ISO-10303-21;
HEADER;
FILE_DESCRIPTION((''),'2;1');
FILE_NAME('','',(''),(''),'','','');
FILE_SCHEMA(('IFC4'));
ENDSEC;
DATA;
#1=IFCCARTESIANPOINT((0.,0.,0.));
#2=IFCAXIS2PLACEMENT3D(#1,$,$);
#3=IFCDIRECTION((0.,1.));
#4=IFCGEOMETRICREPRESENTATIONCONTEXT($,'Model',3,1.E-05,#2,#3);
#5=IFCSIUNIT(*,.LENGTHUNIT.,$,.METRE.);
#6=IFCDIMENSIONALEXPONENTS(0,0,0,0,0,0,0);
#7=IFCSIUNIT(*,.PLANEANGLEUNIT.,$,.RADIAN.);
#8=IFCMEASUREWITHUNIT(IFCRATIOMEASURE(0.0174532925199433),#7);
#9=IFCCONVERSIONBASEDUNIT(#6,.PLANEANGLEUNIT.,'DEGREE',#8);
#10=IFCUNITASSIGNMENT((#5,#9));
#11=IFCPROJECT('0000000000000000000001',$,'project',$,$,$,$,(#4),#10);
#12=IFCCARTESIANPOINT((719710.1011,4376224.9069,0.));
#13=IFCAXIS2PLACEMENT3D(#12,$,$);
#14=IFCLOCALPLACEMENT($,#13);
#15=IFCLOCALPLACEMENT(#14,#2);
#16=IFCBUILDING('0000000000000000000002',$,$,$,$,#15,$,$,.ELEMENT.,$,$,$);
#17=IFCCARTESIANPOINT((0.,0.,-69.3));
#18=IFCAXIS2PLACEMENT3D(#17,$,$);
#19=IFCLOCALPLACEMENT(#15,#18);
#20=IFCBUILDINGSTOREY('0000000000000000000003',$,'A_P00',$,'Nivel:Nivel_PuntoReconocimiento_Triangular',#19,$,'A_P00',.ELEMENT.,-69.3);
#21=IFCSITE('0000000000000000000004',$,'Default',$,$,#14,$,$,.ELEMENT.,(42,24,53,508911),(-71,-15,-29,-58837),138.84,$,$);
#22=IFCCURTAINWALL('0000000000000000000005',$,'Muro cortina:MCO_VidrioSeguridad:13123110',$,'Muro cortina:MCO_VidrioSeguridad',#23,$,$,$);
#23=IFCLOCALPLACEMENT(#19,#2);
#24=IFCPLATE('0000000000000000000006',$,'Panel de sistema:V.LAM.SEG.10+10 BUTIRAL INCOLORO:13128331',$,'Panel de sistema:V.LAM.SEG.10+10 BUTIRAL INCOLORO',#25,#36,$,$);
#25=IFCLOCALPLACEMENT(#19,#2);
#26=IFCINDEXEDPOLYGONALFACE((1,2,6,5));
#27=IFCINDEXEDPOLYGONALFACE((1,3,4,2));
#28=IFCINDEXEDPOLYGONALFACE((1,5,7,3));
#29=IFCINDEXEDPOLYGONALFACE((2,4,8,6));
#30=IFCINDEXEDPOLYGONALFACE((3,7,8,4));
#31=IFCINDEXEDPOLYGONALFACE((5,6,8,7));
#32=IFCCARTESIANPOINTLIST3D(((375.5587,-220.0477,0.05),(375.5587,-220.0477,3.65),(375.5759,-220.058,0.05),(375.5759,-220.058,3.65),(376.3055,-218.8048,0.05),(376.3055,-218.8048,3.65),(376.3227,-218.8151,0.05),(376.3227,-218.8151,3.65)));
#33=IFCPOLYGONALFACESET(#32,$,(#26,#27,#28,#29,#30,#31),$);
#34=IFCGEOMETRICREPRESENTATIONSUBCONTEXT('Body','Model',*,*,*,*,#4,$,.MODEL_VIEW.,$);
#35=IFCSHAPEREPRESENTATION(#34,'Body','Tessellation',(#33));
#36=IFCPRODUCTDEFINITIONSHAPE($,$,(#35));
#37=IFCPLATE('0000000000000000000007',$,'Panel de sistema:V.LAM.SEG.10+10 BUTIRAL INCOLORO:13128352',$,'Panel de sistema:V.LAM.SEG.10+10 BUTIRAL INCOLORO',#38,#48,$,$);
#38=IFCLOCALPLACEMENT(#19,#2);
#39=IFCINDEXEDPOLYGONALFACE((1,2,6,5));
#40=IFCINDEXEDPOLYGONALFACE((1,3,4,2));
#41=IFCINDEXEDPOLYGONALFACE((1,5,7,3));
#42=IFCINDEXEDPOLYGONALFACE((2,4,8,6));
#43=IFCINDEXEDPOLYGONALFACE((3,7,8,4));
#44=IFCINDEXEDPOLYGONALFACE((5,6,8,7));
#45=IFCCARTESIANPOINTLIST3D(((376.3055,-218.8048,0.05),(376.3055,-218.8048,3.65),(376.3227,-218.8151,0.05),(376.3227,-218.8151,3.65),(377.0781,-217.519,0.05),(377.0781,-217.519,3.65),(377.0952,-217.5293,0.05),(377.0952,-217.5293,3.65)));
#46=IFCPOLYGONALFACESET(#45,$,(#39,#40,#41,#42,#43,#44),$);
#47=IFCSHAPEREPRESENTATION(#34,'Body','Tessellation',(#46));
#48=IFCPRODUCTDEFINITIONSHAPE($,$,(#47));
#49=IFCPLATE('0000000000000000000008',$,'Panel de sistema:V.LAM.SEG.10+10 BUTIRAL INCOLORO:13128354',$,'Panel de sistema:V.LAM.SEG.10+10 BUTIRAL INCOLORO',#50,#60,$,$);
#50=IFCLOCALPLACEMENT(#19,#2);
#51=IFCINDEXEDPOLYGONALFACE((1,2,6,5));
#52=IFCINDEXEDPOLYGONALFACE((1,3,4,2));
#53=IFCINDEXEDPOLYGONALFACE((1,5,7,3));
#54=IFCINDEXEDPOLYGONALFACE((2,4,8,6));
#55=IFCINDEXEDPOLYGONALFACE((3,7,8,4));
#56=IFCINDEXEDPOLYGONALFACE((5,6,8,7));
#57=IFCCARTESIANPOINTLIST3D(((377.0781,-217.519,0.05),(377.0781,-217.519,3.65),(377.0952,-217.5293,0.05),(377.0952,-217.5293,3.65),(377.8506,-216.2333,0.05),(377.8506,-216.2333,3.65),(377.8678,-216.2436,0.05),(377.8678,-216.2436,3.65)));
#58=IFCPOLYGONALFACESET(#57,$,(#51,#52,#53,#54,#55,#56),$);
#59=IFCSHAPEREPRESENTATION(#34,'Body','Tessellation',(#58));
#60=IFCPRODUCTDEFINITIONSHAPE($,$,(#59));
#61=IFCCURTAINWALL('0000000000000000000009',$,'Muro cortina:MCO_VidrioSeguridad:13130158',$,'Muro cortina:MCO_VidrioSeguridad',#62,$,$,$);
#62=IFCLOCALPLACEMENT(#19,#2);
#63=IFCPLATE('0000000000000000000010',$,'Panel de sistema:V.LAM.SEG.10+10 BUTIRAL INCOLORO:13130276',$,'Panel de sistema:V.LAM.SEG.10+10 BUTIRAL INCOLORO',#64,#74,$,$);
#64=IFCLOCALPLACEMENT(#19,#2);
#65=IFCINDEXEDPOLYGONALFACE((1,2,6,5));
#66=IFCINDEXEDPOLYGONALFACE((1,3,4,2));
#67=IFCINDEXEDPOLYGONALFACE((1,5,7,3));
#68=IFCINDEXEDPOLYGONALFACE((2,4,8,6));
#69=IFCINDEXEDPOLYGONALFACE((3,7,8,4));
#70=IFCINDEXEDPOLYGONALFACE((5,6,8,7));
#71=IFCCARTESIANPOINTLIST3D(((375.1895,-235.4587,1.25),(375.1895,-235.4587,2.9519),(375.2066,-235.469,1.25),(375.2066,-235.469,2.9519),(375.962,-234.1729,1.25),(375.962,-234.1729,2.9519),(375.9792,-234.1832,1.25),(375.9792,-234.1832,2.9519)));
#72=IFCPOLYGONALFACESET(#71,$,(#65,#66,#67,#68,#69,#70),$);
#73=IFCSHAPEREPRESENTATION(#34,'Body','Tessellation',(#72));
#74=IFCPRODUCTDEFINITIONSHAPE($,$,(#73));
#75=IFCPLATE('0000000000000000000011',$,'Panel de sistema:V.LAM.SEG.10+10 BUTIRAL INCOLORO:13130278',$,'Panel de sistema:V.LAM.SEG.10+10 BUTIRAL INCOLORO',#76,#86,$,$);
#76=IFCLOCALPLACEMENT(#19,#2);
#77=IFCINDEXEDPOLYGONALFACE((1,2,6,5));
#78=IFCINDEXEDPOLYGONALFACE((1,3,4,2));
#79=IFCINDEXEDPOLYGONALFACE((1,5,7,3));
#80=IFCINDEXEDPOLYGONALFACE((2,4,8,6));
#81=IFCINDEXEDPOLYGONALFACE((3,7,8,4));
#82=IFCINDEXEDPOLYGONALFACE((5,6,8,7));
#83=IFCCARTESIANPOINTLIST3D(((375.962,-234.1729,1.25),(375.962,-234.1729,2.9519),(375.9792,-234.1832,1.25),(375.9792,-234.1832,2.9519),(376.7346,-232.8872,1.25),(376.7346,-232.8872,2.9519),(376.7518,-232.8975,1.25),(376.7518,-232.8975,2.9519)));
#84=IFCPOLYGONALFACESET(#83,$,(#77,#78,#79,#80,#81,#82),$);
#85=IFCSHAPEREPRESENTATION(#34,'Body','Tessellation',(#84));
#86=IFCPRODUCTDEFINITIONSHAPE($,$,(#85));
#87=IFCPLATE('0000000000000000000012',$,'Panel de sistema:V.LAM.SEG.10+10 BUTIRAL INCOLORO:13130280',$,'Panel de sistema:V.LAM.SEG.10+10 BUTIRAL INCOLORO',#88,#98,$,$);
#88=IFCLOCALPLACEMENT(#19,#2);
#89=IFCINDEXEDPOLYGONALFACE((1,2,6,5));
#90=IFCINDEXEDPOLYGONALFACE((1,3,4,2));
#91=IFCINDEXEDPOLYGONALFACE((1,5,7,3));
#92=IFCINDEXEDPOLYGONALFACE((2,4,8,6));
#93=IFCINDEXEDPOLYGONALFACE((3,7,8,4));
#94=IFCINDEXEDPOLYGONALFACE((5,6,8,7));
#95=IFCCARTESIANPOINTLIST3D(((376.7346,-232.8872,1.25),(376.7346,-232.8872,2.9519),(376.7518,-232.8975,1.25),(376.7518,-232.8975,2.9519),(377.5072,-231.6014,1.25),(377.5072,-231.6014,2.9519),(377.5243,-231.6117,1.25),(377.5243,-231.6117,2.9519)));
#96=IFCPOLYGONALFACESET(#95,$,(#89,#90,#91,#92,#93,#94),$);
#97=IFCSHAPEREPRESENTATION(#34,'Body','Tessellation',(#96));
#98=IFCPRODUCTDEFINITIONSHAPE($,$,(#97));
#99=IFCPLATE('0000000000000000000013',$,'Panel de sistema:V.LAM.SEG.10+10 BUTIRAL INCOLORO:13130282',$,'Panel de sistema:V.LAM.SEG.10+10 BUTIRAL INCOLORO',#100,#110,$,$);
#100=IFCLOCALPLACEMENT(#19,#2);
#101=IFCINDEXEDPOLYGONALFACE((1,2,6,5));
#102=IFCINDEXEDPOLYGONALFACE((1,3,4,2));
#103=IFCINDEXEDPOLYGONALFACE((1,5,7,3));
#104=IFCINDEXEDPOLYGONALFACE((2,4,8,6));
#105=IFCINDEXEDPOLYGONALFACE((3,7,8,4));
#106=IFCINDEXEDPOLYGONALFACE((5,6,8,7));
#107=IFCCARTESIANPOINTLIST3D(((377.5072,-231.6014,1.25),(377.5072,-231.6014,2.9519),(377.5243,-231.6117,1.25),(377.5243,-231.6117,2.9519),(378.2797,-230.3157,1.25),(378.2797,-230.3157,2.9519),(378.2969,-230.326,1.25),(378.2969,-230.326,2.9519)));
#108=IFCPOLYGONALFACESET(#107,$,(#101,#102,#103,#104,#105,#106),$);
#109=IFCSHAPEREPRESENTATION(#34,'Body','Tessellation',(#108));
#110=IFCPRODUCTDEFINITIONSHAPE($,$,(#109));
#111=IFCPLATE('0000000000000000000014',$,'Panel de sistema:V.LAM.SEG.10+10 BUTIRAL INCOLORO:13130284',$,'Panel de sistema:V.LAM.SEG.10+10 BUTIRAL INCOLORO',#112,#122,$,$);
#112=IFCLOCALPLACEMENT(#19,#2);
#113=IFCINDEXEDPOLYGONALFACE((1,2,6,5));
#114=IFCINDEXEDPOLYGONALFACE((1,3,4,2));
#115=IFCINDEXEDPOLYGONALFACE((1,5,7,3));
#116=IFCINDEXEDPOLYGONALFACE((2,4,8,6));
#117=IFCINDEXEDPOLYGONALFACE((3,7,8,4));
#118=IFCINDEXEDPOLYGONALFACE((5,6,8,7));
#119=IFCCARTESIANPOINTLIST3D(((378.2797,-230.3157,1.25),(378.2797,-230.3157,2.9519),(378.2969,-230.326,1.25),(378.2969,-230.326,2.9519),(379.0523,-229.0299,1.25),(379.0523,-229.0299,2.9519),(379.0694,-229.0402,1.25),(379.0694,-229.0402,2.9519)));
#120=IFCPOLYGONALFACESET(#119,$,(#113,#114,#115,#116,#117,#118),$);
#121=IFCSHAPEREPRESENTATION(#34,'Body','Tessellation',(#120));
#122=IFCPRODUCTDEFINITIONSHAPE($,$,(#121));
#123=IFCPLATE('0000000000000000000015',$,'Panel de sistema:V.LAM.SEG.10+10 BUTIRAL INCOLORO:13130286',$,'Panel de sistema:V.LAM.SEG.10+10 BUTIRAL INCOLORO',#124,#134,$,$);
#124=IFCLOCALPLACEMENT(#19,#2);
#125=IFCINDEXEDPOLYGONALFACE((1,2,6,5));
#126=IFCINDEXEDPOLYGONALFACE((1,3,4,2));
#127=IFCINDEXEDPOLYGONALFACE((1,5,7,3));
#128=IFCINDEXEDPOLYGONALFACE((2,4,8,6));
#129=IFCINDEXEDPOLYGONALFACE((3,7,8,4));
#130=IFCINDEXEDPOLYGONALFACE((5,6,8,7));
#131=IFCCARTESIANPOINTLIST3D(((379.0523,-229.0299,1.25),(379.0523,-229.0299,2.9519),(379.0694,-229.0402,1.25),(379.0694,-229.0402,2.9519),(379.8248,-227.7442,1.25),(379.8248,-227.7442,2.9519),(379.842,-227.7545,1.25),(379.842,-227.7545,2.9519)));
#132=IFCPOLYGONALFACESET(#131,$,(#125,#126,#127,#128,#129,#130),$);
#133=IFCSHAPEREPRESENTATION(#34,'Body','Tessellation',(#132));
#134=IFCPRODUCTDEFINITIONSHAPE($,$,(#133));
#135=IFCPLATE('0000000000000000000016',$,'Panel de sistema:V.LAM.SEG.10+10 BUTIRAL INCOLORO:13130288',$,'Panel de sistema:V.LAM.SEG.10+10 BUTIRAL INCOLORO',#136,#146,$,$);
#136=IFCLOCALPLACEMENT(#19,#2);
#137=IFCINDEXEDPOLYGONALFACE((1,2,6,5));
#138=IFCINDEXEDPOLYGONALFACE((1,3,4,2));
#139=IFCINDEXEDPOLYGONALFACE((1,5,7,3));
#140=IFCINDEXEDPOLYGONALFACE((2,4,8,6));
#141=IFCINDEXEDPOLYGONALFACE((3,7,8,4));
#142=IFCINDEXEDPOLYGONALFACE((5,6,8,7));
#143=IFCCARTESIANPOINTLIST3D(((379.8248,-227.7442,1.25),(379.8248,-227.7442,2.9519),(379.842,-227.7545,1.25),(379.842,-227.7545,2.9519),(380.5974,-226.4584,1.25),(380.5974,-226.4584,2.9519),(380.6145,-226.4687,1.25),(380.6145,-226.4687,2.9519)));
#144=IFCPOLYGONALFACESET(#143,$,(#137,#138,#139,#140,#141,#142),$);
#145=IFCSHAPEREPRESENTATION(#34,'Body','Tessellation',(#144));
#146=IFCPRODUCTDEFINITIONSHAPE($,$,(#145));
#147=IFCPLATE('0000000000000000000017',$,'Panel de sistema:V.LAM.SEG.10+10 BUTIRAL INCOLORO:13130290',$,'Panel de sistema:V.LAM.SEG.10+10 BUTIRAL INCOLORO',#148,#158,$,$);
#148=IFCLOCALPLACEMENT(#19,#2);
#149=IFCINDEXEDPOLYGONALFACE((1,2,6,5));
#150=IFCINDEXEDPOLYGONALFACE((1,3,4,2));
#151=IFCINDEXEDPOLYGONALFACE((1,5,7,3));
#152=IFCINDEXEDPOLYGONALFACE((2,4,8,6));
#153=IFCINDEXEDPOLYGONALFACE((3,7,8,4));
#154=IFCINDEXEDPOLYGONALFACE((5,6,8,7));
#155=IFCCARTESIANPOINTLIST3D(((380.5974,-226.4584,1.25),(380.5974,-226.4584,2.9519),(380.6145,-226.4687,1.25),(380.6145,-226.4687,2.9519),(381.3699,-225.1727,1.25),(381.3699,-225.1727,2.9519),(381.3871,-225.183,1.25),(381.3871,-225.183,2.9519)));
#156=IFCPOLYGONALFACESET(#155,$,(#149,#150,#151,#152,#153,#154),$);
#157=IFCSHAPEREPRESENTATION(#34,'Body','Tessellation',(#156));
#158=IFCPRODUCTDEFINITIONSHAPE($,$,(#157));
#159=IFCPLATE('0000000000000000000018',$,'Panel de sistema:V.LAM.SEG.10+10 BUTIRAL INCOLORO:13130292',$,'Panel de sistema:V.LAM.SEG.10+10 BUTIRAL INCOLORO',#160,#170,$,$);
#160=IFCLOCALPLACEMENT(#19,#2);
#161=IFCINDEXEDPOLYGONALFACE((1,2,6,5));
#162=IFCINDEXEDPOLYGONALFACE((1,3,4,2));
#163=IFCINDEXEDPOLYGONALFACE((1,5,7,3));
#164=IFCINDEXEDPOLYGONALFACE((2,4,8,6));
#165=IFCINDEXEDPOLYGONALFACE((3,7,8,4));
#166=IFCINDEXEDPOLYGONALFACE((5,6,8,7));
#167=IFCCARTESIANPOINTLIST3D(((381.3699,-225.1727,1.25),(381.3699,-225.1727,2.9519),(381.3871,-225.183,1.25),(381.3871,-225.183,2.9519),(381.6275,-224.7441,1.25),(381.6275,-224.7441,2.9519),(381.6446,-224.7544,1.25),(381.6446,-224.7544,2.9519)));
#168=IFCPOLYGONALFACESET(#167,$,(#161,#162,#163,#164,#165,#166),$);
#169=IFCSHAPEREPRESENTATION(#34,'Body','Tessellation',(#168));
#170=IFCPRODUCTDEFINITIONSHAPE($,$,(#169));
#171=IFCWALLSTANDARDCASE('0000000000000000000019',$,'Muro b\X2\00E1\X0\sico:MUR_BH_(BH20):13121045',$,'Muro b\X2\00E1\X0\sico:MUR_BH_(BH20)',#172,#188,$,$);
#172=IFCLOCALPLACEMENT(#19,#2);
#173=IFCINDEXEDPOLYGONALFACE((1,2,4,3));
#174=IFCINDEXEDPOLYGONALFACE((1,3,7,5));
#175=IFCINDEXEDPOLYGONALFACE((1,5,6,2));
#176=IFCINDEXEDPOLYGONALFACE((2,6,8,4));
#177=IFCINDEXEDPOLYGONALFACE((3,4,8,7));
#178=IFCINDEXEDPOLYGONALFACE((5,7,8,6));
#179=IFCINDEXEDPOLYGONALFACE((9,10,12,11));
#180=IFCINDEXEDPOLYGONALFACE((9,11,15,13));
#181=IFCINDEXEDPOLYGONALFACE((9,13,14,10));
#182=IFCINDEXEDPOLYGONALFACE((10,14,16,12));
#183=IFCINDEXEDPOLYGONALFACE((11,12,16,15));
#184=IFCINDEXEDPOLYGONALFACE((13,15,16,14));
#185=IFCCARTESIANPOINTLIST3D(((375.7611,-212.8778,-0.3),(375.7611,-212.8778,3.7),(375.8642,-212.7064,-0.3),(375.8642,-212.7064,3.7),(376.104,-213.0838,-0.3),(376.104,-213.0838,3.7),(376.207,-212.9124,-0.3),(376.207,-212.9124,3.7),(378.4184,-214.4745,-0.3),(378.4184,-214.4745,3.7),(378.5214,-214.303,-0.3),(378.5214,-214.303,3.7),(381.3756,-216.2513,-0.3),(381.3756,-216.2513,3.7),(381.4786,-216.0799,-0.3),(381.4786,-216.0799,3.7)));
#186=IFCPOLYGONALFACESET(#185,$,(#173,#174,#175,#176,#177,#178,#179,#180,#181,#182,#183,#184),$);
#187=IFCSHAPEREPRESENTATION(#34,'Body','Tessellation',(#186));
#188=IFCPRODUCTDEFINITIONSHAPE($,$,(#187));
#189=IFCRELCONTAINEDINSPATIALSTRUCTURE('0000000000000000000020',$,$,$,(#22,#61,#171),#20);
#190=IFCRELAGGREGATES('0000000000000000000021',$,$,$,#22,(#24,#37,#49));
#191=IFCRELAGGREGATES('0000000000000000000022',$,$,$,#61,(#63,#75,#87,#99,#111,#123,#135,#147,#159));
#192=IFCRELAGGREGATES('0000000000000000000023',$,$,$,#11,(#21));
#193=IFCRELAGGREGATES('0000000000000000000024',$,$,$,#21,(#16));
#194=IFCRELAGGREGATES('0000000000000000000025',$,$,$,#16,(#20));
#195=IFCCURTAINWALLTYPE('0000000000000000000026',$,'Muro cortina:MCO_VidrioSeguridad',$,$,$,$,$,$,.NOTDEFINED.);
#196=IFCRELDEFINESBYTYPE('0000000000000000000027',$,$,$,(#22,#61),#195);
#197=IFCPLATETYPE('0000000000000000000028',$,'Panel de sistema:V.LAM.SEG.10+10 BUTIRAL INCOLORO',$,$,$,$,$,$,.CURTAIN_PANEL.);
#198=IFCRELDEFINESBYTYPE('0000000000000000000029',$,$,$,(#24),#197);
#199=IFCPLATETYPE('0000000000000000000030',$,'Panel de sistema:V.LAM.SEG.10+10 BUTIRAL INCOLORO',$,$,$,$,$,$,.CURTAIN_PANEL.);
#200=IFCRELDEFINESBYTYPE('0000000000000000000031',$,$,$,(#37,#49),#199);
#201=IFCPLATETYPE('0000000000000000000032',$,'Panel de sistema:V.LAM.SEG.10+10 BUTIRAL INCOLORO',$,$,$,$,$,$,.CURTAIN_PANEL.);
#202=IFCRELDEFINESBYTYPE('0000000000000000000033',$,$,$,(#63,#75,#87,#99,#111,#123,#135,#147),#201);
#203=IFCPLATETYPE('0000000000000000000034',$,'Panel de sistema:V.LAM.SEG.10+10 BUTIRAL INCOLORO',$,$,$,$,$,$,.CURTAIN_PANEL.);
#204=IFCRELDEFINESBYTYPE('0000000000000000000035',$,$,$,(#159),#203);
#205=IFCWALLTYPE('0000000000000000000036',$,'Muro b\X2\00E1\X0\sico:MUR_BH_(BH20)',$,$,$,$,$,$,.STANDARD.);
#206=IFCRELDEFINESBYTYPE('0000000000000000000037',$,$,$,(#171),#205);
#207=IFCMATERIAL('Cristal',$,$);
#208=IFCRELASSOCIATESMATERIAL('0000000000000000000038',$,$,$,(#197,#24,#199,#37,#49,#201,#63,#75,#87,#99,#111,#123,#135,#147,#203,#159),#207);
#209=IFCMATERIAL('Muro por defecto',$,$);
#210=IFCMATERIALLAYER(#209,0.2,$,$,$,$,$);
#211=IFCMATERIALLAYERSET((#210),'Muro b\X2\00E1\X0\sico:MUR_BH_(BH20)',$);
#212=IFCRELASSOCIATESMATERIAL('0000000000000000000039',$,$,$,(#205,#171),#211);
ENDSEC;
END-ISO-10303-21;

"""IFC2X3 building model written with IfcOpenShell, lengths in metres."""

from ifc_helpers import new_model, entity, si_unit, converted_unit, direction, frame, frame_2d, origin, origin_2d_with_axis, place, context, subcontext, project, spatial, rectangle, extrude, source, transform, mapped, material, layer, layer_set, layer_usage, type_object, type_shapes, element, aggregate, save


model = new_model("IFC2X3")

# Units and contexts
model_context = context("Model", 3, precision=1e-05, world=origin(), true_north=direction((0.0, 1.0)))
body_context = subcontext(model_context, "Body", "Model", "MODEL_VIEW")
ifc_project = project(units=[si_unit("LENGTHUNIT", "METRE"), converted_unit("PLANEANGLEUNIT", "DEGREE", entity("IfcRatioMeasure", 0.0174532925199433), si_unit("PLANEANGLEUNIT", "RADIAN"), dimensions=[0, 0, 0, 0, 0, 0, 0])], contexts=[model_context])

# Site, building, storey
site_placement = place(None, frame((719710.1011, 4376224.9069, 0.0)))
site = spatial("IfcSite", under=ifc_project, at=site_placement, Name="Default", CompositionType="ELEMENT", RefLatitude=(42, 24, 53, 508911), RefLongitude=(-71, -15, -29, -58837), RefElevation=138.84)
building_placement = place(site_placement, origin())
building = spatial("IfcBuilding", under=site, at=building_placement, CompositionType="ELEMENT")
storey_placement = place(building_placement, frame((0.0, 0.0, -69.3)))
storey = spatial("IfcBuildingStorey", under=building, at=storey_placement, Name="A_P00", ObjectType="Nivel:Nivel_PuntoReconocimiento_Triangular", LongName="A_P00", CompositionType="ELEMENT", Elevation=-69.3)

# Curtain walls, plates
curtain_wall_type = type_object("IfcCurtainWallType", Name="Muro cortina:MCO_VidrioSeguridad", PredefinedType="NOTDEFINED")
curtain_wall_1_placement = place(storey_placement, frame((0.0, 0.0, 69.3)))
curtain_wall_1 = element("IfcCurtainWall", 1, at=curtain_wall_1_placement, inside=storey, type_object=curtain_wall_type, Name="Muro cortina:MCO_VidrioSeguridad:13123110", ObjectType="Muro cortina:MCO_VidrioSeguridad")
ifc_material_1 = material(Name="Cristal")
plate_type_1 = type_object("IfcPlateType", Name="Panel de sistema:V.LAM.SEG.10+10 BUTIRAL INCOLORO", PredefinedType="CURTAIN_PANEL", material=ifc_material_1)
shared_shape_1 = source(origin(), body_context, "Body", "SweptSolid", [
    extrude(rectangle(XDim=0.02, YDim=1.45, at=frame_2d((0.0, 0.0), x_axis=(1.0, 0.0))), frame((0.0, 0.0, 0.0), z_axis=(0.0, 0.0, 1.0), x_axis=(0.0, 1.0, 0.0)), (0.0, 0.0, 1.0), 3.6),
])
type_shapes(plate_type_1, [shared_shape_1])
plate_1_placement = place(curtain_wall_1_placement, frame((375.9407, -219.4314, -69.25), z_axis=(0.0, 0.0, 1.0), x_axis=(0.515038, 0.857167, 0.0)))
plate_1 = element("IfcPlate", 2, at=plate_1_placement, type_object=plate_type_1, material=ifc_material_1, Name="Panel de sistema:V.LAM.SEG.10+10 BUTIRAL INCOLORO:13128331", ObjectType="Panel de sistema:V.LAM.SEG.10+10 BUTIRAL INCOLORO", context=body_context, shape_type="MappedRepresentation", body=[
    mapped(shared_shape_1, transform((0.0, 0.0, 0.0), scale=1.0)),
])
plate_type_2 = type_object("IfcPlateType", Name="Panel de sistema:V.LAM.SEG.10+10 BUTIRAL INCOLORO", PredefinedType="CURTAIN_PANEL", material=ifc_material_1)
shared_shape_2 = source(origin(), body_context, "Body", "SweptSolid", [
    extrude(rectangle(XDim=0.02, YDim=1.5, at=frame_2d((0.0, 0.0), x_axis=(1.0, 0.0))), frame((0.0, 0.0, 0.0), z_axis=(0.0, 0.0, 1.0), x_axis=(0.0, 1.0, 0.0)), (0.0, 0.0, 1.0), 3.6),
])
type_shapes(plate_type_2, [shared_shape_2])
plate_2_placement = place(curtain_wall_1_placement, frame((376.7004, -218.167, -69.25), z_axis=(0.0, 0.0, 1.0), x_axis=(0.515038, 0.857167, 0.0)))
plate_2 = element("IfcPlate", 3, at=plate_2_placement, type_object=plate_type_2, material=ifc_material_1, Name="Panel de sistema:V.LAM.SEG.10+10 BUTIRAL INCOLORO:13128352", ObjectType="Panel de sistema:V.LAM.SEG.10+10 BUTIRAL INCOLORO", context=body_context, shape_type="MappedRepresentation", body=[
    mapped(shared_shape_2, transform((0.0, 0.0, 0.0), scale=1.0)),
])
plate_3_placement = place(curtain_wall_1_placement, frame((377.4729, -216.8813, -69.25), z_axis=(0.0, 0.0, 1.0), x_axis=(0.515038, 0.857167, 0.0)))
plate_3 = element("IfcPlate", 4, at=plate_3_placement, type_object=plate_type_2, material=ifc_material_1, Name="Panel de sistema:V.LAM.SEG.10+10 BUTIRAL INCOLORO:13128354", ObjectType="Panel de sistema:V.LAM.SEG.10+10 BUTIRAL INCOLORO", context=body_context, shape_type="MappedRepresentation", body=[
    mapped(shared_shape_2, transform((0.0, 0.0, 0.0), scale=1.0)),
])
aggregate(curtain_wall_1, [plate_1, plate_2, plate_3])
curtain_wall_2_placement = place(storey_placement, frame((0.0, 0.0, 69.3)))
curtain_wall_2 = element("IfcCurtainWall", 5, at=curtain_wall_2_placement, inside=storey, type_object=curtain_wall_type, Name="Muro cortina:MCO_VidrioSeguridad:13130158", ObjectType="Muro cortina:MCO_VidrioSeguridad")
plate_type_3 = type_object("IfcPlateType", Name="Panel de sistema:V.LAM.SEG.10+10 BUTIRAL INCOLORO", PredefinedType="CURTAIN_PANEL", material=ifc_material_1)
shared_shape_3 = source(origin(), body_context, "Body", "SweptSolid", [
    extrude(rectangle(XDim=0.02, YDim=1.5, at=frame_2d((0.0, 0.0), x_axis=(1.0, 0.0))), frame((0.0, 0.0, 0.0), z_axis=(0.0, 0.0, 1.0), x_axis=(0.0, 1.0, 0.0)), (0.0, 0.0, 1.0), 1.7019),
])
type_shapes(plate_type_3, [shared_shape_3])
plate_4_placement = place(curtain_wall_2_placement, frame((375.5843, -234.821, -68.05), z_axis=(0.0, 0.0, 1.0), x_axis=(0.515038, 0.857167, 0.0)))
plate_4 = element("IfcPlate", 6, at=plate_4_placement, type_object=plate_type_3, material=ifc_material_1, Name="Panel de sistema:V.LAM.SEG.10+10 BUTIRAL INCOLORO:13130276", ObjectType="Panel de sistema:V.LAM.SEG.10+10 BUTIRAL INCOLORO", context=body_context, shape_type="MappedRepresentation", body=[
    mapped(shared_shape_3, transform((0.0, 0.0, 0.0), scale=1.0)),
])
plate_5_placement = place(curtain_wall_2_placement, frame((376.3569, -233.5352, -68.05), z_axis=(0.0, 0.0, 1.0), x_axis=(0.515038, 0.857167, 0.0)))
plate_5 = element("IfcPlate", 7, at=plate_5_placement, type_object=plate_type_3, material=ifc_material_1, Name="Panel de sistema:V.LAM.SEG.10+10 BUTIRAL INCOLORO:13130278", ObjectType="Panel de sistema:V.LAM.SEG.10+10 BUTIRAL INCOLORO", context=body_context, shape_type="MappedRepresentation", body=[
    mapped(shared_shape_3, transform((0.0, 0.0, 0.0), scale=1.0)),
])
plate_6_placement = place(curtain_wall_2_placement, frame((377.1295, -232.2495, -68.05), z_axis=(0.0, 0.0, 1.0), x_axis=(0.515038, 0.857167, 0.0)))
plate_6 = element("IfcPlate", 8, at=plate_6_placement, type_object=plate_type_3, material=ifc_material_1, Name="Panel de sistema:V.LAM.SEG.10+10 BUTIRAL INCOLORO:13130280", ObjectType="Panel de sistema:V.LAM.SEG.10+10 BUTIRAL INCOLORO", context=body_context, shape_type="MappedRepresentation", body=[
    mapped(shared_shape_3, transform((0.0, 0.0, 0.0), scale=1.0)),
])
plate_7_placement = place(curtain_wall_2_placement, frame((377.902, -230.9637, -68.05), z_axis=(0.0, 0.0, 1.0), x_axis=(0.515038, 0.857167, 0.0)))
plate_7 = element("IfcPlate", 9, at=plate_7_placement, type_object=plate_type_3, material=ifc_material_1, Name="Panel de sistema:V.LAM.SEG.10+10 BUTIRAL INCOLORO:13130282", ObjectType="Panel de sistema:V.LAM.SEG.10+10 BUTIRAL INCOLORO", context=body_context, shape_type="MappedRepresentation", body=[
    mapped(shared_shape_3, transform((0.0, 0.0, 0.0), scale=1.0)),
])
plate_8_placement = place(curtain_wall_2_placement, frame((378.6746, -229.678, -68.05), z_axis=(0.0, 0.0, 1.0), x_axis=(0.515038, 0.857167, 0.0)))
plate_8 = element("IfcPlate", 10, at=plate_8_placement, type_object=plate_type_3, material=ifc_material_1, Name="Panel de sistema:V.LAM.SEG.10+10 BUTIRAL INCOLORO:13130284", ObjectType="Panel de sistema:V.LAM.SEG.10+10 BUTIRAL INCOLORO", context=body_context, shape_type="MappedRepresentation", body=[
    mapped(shared_shape_3, transform((0.0, 0.0, 0.0), scale=1.0)),
])
plate_9_placement = place(curtain_wall_2_placement, frame((379.4471, -228.3922, -68.05), z_axis=(0.0, 0.0, 1.0), x_axis=(0.515038, 0.857167, 0.0)))
plate_9 = element("IfcPlate", 11, at=plate_9_placement, type_object=plate_type_3, material=ifc_material_1, Name="Panel de sistema:V.LAM.SEG.10+10 BUTIRAL INCOLORO:13130286", ObjectType="Panel de sistema:V.LAM.SEG.10+10 BUTIRAL INCOLORO", context=body_context, shape_type="MappedRepresentation", body=[
    mapped(shared_shape_3, transform((0.0, 0.0, 0.0), scale=1.0)),
])
plate_10_placement = place(curtain_wall_2_placement, frame((380.2197, -227.1065, -68.05), z_axis=(0.0, 0.0, 1.0), x_axis=(0.515038, 0.857167, 0.0)))
plate_10 = element("IfcPlate", 12, at=plate_10_placement, type_object=plate_type_3, material=ifc_material_1, Name="Panel de sistema:V.LAM.SEG.10+10 BUTIRAL INCOLORO:13130288", ObjectType="Panel de sistema:V.LAM.SEG.10+10 BUTIRAL INCOLORO", context=body_context, shape_type="MappedRepresentation", body=[
    mapped(shared_shape_3, transform((0.0, 0.0, 0.0), scale=1.0)),
])
plate_11_placement = place(curtain_wall_2_placement, frame((380.9922, -225.8207, -68.05), z_axis=(0.0, 0.0, 1.0), x_axis=(0.515038, 0.857167, 0.0)))
plate_11 = element("IfcPlate", 13, at=plate_11_placement, type_object=plate_type_3, material=ifc_material_1, Name="Panel de sistema:V.LAM.SEG.10+10 BUTIRAL INCOLORO:13130290", ObjectType="Panel de sistema:V.LAM.SEG.10+10 BUTIRAL INCOLORO", context=body_context, shape_type="MappedRepresentation", body=[
    mapped(shared_shape_3, transform((0.0, 0.0, 0.0), scale=1.0)),
])
plate_type_4 = type_object("IfcPlateType", Name="Panel de sistema:V.LAM.SEG.10+10 BUTIRAL INCOLORO", PredefinedType="CURTAIN_PANEL", material=ifc_material_1)
shared_shape_4 = source(origin(), body_context, "Body", "SweptSolid", [
    extrude(rectangle(XDim=0.02, YDim=0.5, at=origin_2d_with_axis()), frame((0.0, 0.0, 0.0), z_axis=(0.0, 0.0, 1.0), x_axis=(0.0, 1.0, 0.0)), (0.0, 0.0, 1.0), 1.7019),
])
type_shapes(plate_type_4, [shared_shape_4])
plate_12_placement = place(curtain_wall_2_placement, frame((381.5073, -224.9635, -68.05), z_axis=(0.0, 0.0, 1.0), x_axis=(0.515038, 0.857167, 0.0)))
plate_12 = element("IfcPlate", 14, at=plate_12_placement, type_object=plate_type_4, material=ifc_material_1, Name="Panel de sistema:V.LAM.SEG.10+10 BUTIRAL INCOLORO:13130292", ObjectType="Panel de sistema:V.LAM.SEG.10+10 BUTIRAL INCOLORO", context=body_context, shape_type="MappedRepresentation", body=[
    mapped(shared_shape_4, transform((0.0, 0.0, 0.0), scale=1.0)),
])
aggregate(curtain_wall_2, [plate_4, plate_5, plate_6, plate_7, plate_8, plate_9, plate_10, plate_11, plate_12])

# Wall, opening
ifc_material_2 = material(Name="Muro por defecto")
ifc_layer = layer(ifc_material_2, 0.2)
ifc_layer_set = layer_set([ifc_layer], Name="Muro básico:MUR_BH_(BH20)")
ifc_layer_usage_1 = layer_usage(ifc_layer_set, "AXIS2", "NEGATIVE", 0.1)
wall_type = type_object("IfcWallType", Name="Muro básico:MUR_BH_(BH20)", PredefinedType="STANDARD", material=ifc_layer_set)
wall_1_placement = place(storey_placement, frame((381.4271, -216.1656, -0.3), z_axis=(0.0, 0.0, 1.0), x_axis=(-0.857167, 0.515038, 0.0)))
wall_1 = element("IfcWallStandardCase", 15, at=wall_1_placement, inside=storey, type_object=wall_type, material=ifc_layer_usage_1, Name="Muro básico:MUR_BH_(BH20):13121045", ObjectType="Muro básico:MUR_BH_(BH20)", context=body_context, shape_type="SweptSolid", body=[
    extrude(rectangle(XDim=6.55, YDim=0.2, at=frame_2d((3.275, 0.0), x_axis=(-1.0, 0.0))), origin(), (0.0, 0.0, 1.0), 4.0),
])
opening_1_placement = place(wall_1_placement, origin())
element("IfcOpeningElement", 16, at=opening_1_placement, cuts=wall_1, ObjectType="Opening", context=body_context, shape_type="SweptSolid", body=[
    extrude(rectangle(XDim=4.0, YDim=2.7, at=frame_2d((0.0, 0.0), x_axis=(0.0, 1.0))), frame((4.8, -0.2524, 2.0), z_axis=(0.0, 1.0, 0.0), x_axis=(-1.0, 0.0, 0.0)), (0.0, 0.0, 1.0), 0.5048),
])

save(model, "model.ifc")
